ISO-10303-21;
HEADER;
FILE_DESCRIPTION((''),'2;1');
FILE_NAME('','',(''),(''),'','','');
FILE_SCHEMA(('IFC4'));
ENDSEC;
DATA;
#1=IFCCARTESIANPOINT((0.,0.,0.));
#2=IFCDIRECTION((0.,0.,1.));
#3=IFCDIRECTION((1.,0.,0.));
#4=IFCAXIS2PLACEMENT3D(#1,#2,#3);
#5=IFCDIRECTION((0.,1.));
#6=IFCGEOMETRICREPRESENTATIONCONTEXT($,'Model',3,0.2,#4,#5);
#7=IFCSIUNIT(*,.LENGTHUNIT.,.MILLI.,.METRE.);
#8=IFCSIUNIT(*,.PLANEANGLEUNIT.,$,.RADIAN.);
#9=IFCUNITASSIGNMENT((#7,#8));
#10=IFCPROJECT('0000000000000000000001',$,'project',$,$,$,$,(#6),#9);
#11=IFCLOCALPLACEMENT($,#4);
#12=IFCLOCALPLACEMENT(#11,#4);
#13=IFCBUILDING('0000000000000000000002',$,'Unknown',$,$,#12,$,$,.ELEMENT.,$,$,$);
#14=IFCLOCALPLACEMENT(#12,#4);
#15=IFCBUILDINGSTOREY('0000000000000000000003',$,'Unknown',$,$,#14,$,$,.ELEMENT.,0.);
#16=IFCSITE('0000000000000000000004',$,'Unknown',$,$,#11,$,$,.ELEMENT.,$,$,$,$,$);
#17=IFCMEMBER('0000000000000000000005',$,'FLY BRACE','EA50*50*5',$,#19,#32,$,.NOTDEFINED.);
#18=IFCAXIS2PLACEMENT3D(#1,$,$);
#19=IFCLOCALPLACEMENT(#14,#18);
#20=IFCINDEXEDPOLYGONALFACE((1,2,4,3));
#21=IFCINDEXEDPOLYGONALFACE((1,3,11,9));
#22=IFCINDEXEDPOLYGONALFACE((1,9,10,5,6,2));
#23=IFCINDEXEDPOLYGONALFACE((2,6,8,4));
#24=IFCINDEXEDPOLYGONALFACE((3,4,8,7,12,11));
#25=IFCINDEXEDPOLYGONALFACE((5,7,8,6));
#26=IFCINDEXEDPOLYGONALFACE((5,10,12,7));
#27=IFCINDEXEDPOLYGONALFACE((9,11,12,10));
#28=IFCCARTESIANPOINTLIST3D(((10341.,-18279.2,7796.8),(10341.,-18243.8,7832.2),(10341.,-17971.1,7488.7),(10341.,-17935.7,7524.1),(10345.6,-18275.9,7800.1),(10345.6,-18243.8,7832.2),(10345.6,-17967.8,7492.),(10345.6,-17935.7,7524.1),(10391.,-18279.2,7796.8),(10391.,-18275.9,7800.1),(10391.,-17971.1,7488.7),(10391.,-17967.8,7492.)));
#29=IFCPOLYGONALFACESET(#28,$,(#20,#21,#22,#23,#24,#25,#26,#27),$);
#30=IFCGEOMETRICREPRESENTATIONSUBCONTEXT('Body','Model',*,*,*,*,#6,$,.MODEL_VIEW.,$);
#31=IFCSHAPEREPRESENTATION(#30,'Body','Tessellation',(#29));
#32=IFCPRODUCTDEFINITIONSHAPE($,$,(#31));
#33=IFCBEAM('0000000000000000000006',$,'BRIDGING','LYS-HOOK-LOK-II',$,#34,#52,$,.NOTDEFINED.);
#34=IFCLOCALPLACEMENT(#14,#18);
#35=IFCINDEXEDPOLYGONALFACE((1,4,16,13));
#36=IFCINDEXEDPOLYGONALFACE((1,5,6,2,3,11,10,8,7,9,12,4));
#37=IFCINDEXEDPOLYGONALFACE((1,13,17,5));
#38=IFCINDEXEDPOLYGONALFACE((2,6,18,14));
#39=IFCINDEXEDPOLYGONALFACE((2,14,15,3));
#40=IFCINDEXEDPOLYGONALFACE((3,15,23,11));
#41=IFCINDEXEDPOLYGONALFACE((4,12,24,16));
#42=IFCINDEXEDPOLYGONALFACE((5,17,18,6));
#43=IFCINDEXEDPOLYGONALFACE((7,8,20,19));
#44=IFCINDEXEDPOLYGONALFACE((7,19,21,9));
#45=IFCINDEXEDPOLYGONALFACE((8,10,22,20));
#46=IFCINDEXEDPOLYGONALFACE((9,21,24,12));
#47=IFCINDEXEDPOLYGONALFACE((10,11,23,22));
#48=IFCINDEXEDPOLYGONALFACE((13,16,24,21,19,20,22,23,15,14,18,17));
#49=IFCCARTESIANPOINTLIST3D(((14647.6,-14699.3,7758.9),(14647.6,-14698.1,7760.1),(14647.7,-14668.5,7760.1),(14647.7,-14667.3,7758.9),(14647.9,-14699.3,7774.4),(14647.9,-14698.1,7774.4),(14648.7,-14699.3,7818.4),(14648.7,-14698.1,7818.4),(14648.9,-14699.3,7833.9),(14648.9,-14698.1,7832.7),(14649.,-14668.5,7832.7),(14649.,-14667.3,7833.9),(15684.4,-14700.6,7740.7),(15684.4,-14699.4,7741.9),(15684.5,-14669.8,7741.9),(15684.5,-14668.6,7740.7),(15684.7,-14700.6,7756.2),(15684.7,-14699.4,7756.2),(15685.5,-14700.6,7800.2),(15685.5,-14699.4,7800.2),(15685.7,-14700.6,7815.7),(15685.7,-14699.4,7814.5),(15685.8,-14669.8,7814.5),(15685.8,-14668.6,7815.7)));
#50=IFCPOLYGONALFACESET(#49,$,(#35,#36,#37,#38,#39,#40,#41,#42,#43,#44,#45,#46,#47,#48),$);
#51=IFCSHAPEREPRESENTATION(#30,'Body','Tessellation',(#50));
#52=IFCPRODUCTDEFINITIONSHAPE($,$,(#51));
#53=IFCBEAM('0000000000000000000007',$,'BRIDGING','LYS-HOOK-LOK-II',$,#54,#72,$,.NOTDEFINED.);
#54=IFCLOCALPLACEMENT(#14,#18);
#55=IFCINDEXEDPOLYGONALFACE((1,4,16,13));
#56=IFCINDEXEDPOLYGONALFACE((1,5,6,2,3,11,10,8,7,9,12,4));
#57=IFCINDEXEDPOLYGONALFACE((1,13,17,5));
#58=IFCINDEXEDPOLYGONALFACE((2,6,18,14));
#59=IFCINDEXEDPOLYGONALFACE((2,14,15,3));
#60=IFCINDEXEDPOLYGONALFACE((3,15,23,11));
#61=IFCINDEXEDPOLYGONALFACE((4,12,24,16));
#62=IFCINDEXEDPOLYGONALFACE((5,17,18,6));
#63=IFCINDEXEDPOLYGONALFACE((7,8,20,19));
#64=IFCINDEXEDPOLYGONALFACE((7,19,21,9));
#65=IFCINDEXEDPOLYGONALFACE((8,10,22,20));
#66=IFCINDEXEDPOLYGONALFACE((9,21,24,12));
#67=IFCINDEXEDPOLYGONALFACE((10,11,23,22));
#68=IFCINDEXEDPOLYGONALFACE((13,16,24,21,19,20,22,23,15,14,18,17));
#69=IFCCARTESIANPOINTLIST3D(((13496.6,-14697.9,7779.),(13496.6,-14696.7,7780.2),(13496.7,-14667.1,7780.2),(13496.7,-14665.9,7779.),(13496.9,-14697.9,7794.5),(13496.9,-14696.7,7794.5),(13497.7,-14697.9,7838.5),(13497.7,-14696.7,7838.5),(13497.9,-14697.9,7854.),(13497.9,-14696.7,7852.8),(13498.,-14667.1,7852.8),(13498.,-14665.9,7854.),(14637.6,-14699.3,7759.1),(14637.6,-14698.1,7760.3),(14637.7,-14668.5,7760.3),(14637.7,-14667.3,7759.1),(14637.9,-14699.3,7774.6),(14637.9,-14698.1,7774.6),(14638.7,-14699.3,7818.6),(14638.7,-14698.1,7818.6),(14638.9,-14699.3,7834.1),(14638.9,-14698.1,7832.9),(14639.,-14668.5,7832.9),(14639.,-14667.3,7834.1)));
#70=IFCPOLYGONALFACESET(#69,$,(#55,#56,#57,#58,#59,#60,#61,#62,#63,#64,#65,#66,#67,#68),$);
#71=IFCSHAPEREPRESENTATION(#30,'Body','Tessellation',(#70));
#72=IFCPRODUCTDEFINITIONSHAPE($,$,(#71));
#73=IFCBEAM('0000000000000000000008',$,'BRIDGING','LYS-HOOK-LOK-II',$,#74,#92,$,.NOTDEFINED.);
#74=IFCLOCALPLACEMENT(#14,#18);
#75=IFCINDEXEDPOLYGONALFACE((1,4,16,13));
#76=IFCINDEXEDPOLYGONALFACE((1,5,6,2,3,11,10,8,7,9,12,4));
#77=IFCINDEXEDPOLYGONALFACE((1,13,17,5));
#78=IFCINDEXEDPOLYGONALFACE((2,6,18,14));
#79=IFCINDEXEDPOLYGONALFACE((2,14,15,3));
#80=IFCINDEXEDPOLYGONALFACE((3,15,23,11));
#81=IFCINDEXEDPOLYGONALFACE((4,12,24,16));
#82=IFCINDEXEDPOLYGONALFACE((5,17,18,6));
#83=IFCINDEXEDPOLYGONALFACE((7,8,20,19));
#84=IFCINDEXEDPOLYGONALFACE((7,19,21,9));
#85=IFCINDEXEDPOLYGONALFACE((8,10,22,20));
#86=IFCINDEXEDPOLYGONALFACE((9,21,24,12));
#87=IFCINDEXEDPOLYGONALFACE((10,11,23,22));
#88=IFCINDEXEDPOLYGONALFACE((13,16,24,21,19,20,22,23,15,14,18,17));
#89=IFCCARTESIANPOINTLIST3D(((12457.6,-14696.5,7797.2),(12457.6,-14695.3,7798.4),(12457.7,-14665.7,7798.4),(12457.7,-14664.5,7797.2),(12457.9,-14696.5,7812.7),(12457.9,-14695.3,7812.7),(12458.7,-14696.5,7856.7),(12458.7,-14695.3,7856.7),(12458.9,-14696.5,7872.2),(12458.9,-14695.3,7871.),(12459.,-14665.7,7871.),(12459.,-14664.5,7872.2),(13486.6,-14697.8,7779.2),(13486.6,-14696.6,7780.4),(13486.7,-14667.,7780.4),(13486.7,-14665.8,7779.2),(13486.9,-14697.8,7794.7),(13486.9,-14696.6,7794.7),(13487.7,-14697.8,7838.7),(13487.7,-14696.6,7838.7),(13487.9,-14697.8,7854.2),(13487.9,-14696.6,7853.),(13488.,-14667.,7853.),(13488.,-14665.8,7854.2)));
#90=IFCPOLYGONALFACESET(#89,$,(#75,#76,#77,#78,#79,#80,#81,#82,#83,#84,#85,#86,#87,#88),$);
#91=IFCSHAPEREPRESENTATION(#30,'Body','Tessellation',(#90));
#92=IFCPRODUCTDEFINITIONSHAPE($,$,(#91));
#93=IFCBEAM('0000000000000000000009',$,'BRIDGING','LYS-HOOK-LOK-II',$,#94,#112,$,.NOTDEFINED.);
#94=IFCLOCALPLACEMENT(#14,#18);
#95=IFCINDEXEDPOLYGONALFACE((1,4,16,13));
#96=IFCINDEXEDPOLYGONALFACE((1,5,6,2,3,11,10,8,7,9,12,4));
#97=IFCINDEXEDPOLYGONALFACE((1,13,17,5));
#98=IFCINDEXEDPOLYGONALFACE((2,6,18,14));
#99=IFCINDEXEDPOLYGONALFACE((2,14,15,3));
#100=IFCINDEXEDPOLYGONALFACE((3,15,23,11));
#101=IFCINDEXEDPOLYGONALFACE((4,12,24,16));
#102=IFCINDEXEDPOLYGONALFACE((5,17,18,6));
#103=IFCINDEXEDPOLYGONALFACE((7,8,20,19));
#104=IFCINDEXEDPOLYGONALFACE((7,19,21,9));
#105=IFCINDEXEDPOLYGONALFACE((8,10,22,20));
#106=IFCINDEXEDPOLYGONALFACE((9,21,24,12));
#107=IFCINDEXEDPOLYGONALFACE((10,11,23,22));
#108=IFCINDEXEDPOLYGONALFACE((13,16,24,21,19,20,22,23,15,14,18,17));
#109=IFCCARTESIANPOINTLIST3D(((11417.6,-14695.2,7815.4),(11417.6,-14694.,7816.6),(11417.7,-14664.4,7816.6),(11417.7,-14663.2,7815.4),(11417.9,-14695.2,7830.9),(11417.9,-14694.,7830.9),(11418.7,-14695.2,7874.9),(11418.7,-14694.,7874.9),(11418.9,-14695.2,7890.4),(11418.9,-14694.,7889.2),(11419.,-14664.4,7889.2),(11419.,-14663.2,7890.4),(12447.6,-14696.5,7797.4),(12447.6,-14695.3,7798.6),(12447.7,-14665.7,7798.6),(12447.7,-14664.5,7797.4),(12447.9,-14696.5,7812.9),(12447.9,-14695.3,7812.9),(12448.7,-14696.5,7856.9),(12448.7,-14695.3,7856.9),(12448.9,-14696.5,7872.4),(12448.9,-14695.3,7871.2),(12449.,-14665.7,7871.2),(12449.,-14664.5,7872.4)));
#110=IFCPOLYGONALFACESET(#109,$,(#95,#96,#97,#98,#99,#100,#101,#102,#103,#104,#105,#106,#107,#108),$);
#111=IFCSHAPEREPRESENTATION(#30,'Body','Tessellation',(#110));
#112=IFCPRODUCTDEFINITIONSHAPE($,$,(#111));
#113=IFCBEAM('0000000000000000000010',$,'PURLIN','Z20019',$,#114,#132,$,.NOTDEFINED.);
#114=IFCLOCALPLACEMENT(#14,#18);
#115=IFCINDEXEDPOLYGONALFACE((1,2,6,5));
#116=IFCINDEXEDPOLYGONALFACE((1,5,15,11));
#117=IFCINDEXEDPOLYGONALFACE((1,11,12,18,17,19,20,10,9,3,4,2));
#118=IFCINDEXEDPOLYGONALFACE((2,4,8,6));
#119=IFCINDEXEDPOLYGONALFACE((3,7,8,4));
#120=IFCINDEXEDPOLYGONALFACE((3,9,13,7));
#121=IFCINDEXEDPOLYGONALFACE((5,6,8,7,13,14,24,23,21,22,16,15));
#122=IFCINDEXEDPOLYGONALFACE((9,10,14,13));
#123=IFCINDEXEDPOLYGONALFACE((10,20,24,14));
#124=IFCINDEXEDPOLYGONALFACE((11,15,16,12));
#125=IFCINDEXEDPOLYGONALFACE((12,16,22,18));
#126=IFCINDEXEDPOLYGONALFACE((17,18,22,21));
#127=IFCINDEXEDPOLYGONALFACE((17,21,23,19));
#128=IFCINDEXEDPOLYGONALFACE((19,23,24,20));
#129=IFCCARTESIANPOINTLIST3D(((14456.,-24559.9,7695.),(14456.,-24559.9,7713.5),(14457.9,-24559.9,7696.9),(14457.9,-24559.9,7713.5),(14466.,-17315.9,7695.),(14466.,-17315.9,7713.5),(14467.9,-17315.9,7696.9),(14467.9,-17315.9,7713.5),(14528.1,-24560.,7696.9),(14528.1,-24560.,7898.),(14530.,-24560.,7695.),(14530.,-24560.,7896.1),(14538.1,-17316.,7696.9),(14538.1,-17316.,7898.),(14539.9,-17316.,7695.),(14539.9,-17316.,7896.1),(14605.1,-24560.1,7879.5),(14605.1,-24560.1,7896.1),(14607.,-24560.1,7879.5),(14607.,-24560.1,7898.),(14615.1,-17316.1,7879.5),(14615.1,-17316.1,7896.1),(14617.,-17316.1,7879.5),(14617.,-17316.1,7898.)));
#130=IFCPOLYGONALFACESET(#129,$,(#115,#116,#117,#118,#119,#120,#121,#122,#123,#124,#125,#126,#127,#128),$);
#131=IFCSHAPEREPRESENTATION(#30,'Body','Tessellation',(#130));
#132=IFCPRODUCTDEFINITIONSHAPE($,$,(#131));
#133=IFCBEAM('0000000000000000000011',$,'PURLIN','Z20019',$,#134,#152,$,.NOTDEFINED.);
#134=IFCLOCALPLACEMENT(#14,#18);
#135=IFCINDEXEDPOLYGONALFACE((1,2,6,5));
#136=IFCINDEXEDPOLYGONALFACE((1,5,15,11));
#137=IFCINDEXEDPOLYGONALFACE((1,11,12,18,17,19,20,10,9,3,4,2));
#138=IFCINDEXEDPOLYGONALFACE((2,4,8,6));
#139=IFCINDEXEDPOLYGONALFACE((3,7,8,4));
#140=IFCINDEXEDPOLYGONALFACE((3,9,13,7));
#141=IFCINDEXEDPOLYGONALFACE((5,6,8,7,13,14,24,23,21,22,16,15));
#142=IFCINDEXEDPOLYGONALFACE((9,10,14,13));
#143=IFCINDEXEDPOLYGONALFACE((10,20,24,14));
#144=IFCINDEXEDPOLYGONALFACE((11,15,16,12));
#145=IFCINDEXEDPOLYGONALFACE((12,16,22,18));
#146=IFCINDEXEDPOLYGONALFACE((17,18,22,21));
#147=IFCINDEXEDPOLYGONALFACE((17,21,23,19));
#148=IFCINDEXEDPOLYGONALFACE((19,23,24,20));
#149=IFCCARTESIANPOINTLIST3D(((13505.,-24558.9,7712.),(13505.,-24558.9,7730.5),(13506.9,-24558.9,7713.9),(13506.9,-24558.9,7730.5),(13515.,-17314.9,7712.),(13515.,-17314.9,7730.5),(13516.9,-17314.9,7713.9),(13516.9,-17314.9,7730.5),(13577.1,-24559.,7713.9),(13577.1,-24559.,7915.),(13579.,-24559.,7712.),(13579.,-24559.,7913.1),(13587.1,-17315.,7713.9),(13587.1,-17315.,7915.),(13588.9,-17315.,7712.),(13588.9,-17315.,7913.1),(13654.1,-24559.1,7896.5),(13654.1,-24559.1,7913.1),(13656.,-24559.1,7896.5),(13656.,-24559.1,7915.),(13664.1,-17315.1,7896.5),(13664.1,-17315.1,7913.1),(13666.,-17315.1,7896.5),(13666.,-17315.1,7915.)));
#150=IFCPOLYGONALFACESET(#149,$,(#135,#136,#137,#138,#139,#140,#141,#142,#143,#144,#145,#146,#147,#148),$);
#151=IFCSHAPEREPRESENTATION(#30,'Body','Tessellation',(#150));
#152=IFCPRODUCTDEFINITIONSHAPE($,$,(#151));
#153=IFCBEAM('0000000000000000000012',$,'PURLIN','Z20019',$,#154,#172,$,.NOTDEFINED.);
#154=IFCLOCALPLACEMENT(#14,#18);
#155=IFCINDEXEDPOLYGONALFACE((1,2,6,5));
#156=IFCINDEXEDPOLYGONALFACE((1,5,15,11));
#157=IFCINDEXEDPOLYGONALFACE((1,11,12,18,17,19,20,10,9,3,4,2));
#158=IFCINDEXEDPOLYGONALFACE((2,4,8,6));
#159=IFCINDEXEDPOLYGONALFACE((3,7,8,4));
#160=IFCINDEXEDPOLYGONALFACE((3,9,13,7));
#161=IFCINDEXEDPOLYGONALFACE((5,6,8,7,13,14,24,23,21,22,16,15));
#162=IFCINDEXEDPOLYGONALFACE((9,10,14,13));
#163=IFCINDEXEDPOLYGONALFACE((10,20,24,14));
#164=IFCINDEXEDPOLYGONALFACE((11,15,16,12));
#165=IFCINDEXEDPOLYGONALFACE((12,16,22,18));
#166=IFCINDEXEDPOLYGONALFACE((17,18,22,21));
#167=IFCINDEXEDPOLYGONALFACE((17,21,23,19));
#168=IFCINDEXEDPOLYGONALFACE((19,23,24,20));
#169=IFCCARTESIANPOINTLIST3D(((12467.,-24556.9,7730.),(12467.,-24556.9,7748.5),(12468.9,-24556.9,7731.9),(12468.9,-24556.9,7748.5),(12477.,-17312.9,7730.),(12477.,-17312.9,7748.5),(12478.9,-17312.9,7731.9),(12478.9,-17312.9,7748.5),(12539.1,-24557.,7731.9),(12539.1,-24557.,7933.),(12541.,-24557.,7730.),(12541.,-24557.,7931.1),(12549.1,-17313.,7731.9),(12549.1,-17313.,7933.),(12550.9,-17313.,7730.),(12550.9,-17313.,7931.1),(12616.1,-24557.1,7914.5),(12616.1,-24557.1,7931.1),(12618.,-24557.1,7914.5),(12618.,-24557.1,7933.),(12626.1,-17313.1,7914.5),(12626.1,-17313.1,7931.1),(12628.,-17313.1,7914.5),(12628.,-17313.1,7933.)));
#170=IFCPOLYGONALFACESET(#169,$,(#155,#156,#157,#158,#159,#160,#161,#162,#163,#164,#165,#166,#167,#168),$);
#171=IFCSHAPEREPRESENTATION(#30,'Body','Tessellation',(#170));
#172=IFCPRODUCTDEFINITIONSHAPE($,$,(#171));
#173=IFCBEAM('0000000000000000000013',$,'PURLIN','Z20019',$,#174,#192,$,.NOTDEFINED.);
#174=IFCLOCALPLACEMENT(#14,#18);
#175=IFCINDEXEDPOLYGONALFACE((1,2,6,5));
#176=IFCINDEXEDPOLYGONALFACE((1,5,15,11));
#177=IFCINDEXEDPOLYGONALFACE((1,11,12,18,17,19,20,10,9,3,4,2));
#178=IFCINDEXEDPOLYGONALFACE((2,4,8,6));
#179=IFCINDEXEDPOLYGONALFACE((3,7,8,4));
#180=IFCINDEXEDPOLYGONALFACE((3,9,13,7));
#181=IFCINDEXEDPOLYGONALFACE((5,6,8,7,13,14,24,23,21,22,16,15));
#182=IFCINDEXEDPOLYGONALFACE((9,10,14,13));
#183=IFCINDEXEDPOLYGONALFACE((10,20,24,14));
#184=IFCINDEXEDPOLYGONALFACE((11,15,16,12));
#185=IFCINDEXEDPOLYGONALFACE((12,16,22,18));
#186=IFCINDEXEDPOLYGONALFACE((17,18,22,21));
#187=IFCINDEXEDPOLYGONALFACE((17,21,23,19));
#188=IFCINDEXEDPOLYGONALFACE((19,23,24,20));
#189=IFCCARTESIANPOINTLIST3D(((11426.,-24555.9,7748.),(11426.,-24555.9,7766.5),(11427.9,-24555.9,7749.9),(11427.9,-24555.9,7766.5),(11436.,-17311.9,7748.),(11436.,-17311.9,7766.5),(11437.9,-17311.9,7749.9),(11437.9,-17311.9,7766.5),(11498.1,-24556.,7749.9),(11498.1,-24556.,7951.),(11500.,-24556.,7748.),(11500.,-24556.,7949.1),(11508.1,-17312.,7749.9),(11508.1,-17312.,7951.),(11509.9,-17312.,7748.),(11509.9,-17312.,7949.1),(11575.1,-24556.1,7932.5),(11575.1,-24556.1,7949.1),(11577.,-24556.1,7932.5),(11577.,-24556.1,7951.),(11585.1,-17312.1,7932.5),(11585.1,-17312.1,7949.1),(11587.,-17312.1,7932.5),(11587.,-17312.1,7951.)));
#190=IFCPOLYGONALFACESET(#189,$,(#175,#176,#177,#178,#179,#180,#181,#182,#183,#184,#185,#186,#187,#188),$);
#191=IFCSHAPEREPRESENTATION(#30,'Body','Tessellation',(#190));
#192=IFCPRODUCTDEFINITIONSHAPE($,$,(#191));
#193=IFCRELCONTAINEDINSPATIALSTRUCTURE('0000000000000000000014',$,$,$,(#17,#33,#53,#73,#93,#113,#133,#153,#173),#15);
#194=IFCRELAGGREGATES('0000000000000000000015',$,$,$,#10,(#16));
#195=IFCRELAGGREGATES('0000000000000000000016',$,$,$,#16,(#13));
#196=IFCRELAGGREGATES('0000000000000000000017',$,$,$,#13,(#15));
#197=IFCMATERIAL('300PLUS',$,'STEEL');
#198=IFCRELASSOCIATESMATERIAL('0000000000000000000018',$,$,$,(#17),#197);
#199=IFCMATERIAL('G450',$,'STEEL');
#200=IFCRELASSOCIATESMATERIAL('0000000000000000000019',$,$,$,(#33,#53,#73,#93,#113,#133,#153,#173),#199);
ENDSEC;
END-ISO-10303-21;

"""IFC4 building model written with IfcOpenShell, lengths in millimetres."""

from ifc_helpers import new_model, si_unit, direction, frame, origin_with_axes, place, context, subcontext, project, spatial, line, indexed_curve, outline, extrude, material, element, save


model = new_model("IFC4")

# Units and contexts
model_context = context("Model", 3, precision=0.2, world=origin_with_axes(), true_north=direction((0.0, 1.0)))
body_context = subcontext(model_context, "Body", "Model", "MODEL_VIEW")
ifc_project = project(units=[si_unit("LENGTHUNIT", "METRE", prefix="MILLI"), si_unit("PLANEANGLEUNIT", "RADIAN")], contexts=[model_context])

# Site, building, storey
site_placement = place(None, origin_with_axes())
site = spatial("IfcSite", under=ifc_project, at=site_placement, Name="Unknown", CompositionType="ELEMENT")
building_placement = place(site_placement, origin_with_axes())
building = spatial("IfcBuilding", under=site, at=building_placement, Name="Unknown", CompositionType="ELEMENT")
storey_placement = place(building_placement, origin_with_axes())
storey = spatial("IfcBuildingStorey", under=building, at=storey_placement, Name="Unknown", CompositionType="ELEMENT", Elevation=0.0)

# Member
ifc_material_1 = material(Name="300PLUS", Category="STEEL")
member_placement = place(storey_placement, frame((10366.0, -17953.4, 7506.4), z_axis=(0.0, 0.707107, 0.707107), x_axis=(0.0, -0.707107, 0.707107)))
element("IfcMember", 1, at=member_placement, inside=storey, material=ifc_material_1, Name="FLY BRACE", Description="EA50*50*5", PredefinedType="NOTDEFINED", context=body_context, shape_type="SolidModel", body=[
    extrude(outline(indexed_curve([(-25.0, -25.0), (25.0, -25.0), (25.0, -20.4), (-20.4, -20.4), (-20.4, 25.0), (-25.0, 25.0)], segments=[line(1, 2, 3, 4, 5, 6, 1)])), frame((0.0, 0.0, 0.0), z_axis=(-1.0, 0.0, 0.0), x_axis=(0.0, 0.0, 1.0)), (0.0, 0.0, -1.0), 435.7),
])

# Beams
ifc_material_2 = material(Name="G450", Category="STEEL")
beam_1_placement = place(storey_placement, frame((14648.3, -14683.3, 7796.4), z_axis=(-0.001254, -0.999999, 0.0), x_axis=(0.999845, -0.001254, -0.017551)))
element("IfcBeam", 2, at=beam_1_placement, inside=storey, material=ifc_material_2, Name="BRIDGING", Description="LYS-HOOK-LOK-II", PredefinedType="NOTDEFINED", context=body_context, shape_type="SolidModel", body=[
    extrude(outline(indexed_curve([(16.0, -37.5), (16.0, -22.0), (14.8, -22.0), (14.8, -36.3), (-14.8, -36.3), (-14.8, 36.3), (14.8, 36.3), (14.8, 22.0), (16.0, 22.0), (16.0, 37.5), (-16.0, 37.5), (-16.0, -37.5)], segments=[line(1, 2, 3, 4, 5, 6, 7, 8, 9, 10, 11, 12, 1)])), frame((0.0, 0.0, 0.0), z_axis=(-1.0, 0.0, 0.0), x_axis=(0.0, 0.0, 1.0)), (0.0, 0.0, -1.0), 1037.0),
])
beam_2_placement = place(storey_placement, frame((13497.3, -14681.9, 7816.5), z_axis=(-0.001227, -0.999999, 0.0), x_axis=(0.999847, -0.001227, -0.017438)))
element("IfcBeam", 3, at=beam_2_placement, inside=storey, material=ifc_material_2, Name="BRIDGING", Description="LYS-HOOK-LOK-II", PredefinedType="NOTDEFINED", context=body_context, shape_type="SolidModel", body=[
    extrude(outline(indexed_curve([(16.0, -37.5), (16.0, -22.0), (14.8, -22.0), (14.8, -36.3), (-14.8, -36.3), (-14.8, 36.3), (14.8, 36.3), (14.8, 22.0), (16.0, 22.0), (16.0, 37.5), (-16.0, 37.5), (-16.0, -37.5)], segments=[line(1, 2, 3, 4, 5, 6, 7, 8, 9, 10, 11, 12, 1)])), frame((0.0, 0.0, 0.0), z_axis=(-1.0, 0.0, 0.0), x_axis=(0.0, 0.0, 1.0)), (0.0, 0.0, -1.0), 1141.2),
])
beam_3_placement = place(storey_placement, frame((12458.3, -14680.5, 7834.7), z_axis=(-0.001263, -0.999999, 0.0), x_axis=(0.999846, -0.001263, -0.01749)))
element("IfcBeam", 4, at=beam_3_placement, inside=storey, material=ifc_material_2, Name="BRIDGING", Description="LYS-HOOK-LOK-II", PredefinedType="NOTDEFINED", context=body_context, shape_type="SolidModel", body=[
    extrude(outline(indexed_curve([(16.0, -37.5), (16.0, -22.0), (14.8, -22.0), (14.8, -36.3), (-14.8, -36.3), (-14.8, 36.3), (14.8, 36.3), (14.8, 22.0), (16.0, 22.0), (16.0, 37.5), (-16.0, 37.5), (-16.0, -37.5)], segments=[line(1, 2, 3, 4, 5, 6, 7, 8, 9, 10, 11, 12, 1)])), frame((0.0, 0.0, 0.0), z_axis=(-1.0, 0.0, 0.0), x_axis=(0.0, 0.0, 1.0)), (0.0, 0.0, -1.0), 1029.2),
])
beam_4_placement = place(storey_placement, frame((11418.3, -14679.2, 7852.9), z_axis=(-0.001262, -0.999999, 0.0), x_axis=(0.999847, -0.001262, -0.017473)))
element("IfcBeam", 5, at=beam_4_placement, inside=storey, material=ifc_material_2, Name="BRIDGING", Description="LYS-HOOK-LOK-II", PredefinedType="NOTDEFINED", context=body_context, shape_type="SolidModel", body=[
    extrude(outline(indexed_curve([(16.0, -37.5), (16.0, -22.0), (14.8, -22.0), (14.8, -36.3), (-14.8, -36.3), (-14.8, 36.3), (14.8, 36.3), (14.8, 22.0), (16.0, 22.0), (16.0, 37.5), (-16.0, 37.5), (-16.0, -37.5)], segments=[line(1, 2, 3, 4, 5, 6, 7, 8, 9, 10, 11, 12, 1)])), frame((0.0, 0.0, 0.0), z_axis=(-1.0, 0.0, 0.0), x_axis=(0.0, 0.0, 1.0)), (0.0, 0.0, -1.0), 1030.2),
])
for number, where, z_axis, x_axis, name in (
    (6, (14539.0, -17316.0, 7796.5), (-0.999999, 0.00138, 0.0), (-0.00138, -0.999999, 0.0), "PURLIN"),
    (7, (13588.0, -17315.0, 7813.5), (-0.999999, 0.00138, 0.0), (-0.00138, -0.999999, 0.0), "PURLIN"),
    (8, (12550.0, -17313.0, 7831.5), (-0.999999, 0.00138, 0.0), (-0.00138, -0.999999, 0.0), "PURLIN"),
    (9, (11509.0, -17312.0, 7849.5), (-0.999999, 0.00138, 0.0), (-0.00138, -0.999999, 0.0), "PURLIN"),
):
    element("IfcBeam", number, at=place(storey_placement, frame(where, z_axis=z_axis, x_axis=x_axis)), inside=storey, material=ifc_material_2, Name=name, Description="Z20019", PredefinedType="NOTDEFINED", context=body_context, shape_type="SolidModel", body=[
        extrude(outline(indexed_curve([(73.0, -101.5), (73.0, -83.0), (71.2, -83.0), (71.2, -99.6), (0.9, -99.6), (0.9, 101.5), (-78.0, 101.5), (-78.0, 83.0), (-76.2, 83.0), (-76.2, 99.6), (-0.9, 99.6), (-0.9, -101.5)], segments=[line(1, 2, 3, 4, 5, 6, 7, 8, 9, 10, 11, 12, 1)])), frame((0.0, 0.0, 0.0), z_axis=(-1.0, 0.0, 0.0), x_axis=(0.0, 0.0, 1.0)), (0.0, 0.0, -1.0), 7244.0),
    ])

save(model, "model.ifc")
